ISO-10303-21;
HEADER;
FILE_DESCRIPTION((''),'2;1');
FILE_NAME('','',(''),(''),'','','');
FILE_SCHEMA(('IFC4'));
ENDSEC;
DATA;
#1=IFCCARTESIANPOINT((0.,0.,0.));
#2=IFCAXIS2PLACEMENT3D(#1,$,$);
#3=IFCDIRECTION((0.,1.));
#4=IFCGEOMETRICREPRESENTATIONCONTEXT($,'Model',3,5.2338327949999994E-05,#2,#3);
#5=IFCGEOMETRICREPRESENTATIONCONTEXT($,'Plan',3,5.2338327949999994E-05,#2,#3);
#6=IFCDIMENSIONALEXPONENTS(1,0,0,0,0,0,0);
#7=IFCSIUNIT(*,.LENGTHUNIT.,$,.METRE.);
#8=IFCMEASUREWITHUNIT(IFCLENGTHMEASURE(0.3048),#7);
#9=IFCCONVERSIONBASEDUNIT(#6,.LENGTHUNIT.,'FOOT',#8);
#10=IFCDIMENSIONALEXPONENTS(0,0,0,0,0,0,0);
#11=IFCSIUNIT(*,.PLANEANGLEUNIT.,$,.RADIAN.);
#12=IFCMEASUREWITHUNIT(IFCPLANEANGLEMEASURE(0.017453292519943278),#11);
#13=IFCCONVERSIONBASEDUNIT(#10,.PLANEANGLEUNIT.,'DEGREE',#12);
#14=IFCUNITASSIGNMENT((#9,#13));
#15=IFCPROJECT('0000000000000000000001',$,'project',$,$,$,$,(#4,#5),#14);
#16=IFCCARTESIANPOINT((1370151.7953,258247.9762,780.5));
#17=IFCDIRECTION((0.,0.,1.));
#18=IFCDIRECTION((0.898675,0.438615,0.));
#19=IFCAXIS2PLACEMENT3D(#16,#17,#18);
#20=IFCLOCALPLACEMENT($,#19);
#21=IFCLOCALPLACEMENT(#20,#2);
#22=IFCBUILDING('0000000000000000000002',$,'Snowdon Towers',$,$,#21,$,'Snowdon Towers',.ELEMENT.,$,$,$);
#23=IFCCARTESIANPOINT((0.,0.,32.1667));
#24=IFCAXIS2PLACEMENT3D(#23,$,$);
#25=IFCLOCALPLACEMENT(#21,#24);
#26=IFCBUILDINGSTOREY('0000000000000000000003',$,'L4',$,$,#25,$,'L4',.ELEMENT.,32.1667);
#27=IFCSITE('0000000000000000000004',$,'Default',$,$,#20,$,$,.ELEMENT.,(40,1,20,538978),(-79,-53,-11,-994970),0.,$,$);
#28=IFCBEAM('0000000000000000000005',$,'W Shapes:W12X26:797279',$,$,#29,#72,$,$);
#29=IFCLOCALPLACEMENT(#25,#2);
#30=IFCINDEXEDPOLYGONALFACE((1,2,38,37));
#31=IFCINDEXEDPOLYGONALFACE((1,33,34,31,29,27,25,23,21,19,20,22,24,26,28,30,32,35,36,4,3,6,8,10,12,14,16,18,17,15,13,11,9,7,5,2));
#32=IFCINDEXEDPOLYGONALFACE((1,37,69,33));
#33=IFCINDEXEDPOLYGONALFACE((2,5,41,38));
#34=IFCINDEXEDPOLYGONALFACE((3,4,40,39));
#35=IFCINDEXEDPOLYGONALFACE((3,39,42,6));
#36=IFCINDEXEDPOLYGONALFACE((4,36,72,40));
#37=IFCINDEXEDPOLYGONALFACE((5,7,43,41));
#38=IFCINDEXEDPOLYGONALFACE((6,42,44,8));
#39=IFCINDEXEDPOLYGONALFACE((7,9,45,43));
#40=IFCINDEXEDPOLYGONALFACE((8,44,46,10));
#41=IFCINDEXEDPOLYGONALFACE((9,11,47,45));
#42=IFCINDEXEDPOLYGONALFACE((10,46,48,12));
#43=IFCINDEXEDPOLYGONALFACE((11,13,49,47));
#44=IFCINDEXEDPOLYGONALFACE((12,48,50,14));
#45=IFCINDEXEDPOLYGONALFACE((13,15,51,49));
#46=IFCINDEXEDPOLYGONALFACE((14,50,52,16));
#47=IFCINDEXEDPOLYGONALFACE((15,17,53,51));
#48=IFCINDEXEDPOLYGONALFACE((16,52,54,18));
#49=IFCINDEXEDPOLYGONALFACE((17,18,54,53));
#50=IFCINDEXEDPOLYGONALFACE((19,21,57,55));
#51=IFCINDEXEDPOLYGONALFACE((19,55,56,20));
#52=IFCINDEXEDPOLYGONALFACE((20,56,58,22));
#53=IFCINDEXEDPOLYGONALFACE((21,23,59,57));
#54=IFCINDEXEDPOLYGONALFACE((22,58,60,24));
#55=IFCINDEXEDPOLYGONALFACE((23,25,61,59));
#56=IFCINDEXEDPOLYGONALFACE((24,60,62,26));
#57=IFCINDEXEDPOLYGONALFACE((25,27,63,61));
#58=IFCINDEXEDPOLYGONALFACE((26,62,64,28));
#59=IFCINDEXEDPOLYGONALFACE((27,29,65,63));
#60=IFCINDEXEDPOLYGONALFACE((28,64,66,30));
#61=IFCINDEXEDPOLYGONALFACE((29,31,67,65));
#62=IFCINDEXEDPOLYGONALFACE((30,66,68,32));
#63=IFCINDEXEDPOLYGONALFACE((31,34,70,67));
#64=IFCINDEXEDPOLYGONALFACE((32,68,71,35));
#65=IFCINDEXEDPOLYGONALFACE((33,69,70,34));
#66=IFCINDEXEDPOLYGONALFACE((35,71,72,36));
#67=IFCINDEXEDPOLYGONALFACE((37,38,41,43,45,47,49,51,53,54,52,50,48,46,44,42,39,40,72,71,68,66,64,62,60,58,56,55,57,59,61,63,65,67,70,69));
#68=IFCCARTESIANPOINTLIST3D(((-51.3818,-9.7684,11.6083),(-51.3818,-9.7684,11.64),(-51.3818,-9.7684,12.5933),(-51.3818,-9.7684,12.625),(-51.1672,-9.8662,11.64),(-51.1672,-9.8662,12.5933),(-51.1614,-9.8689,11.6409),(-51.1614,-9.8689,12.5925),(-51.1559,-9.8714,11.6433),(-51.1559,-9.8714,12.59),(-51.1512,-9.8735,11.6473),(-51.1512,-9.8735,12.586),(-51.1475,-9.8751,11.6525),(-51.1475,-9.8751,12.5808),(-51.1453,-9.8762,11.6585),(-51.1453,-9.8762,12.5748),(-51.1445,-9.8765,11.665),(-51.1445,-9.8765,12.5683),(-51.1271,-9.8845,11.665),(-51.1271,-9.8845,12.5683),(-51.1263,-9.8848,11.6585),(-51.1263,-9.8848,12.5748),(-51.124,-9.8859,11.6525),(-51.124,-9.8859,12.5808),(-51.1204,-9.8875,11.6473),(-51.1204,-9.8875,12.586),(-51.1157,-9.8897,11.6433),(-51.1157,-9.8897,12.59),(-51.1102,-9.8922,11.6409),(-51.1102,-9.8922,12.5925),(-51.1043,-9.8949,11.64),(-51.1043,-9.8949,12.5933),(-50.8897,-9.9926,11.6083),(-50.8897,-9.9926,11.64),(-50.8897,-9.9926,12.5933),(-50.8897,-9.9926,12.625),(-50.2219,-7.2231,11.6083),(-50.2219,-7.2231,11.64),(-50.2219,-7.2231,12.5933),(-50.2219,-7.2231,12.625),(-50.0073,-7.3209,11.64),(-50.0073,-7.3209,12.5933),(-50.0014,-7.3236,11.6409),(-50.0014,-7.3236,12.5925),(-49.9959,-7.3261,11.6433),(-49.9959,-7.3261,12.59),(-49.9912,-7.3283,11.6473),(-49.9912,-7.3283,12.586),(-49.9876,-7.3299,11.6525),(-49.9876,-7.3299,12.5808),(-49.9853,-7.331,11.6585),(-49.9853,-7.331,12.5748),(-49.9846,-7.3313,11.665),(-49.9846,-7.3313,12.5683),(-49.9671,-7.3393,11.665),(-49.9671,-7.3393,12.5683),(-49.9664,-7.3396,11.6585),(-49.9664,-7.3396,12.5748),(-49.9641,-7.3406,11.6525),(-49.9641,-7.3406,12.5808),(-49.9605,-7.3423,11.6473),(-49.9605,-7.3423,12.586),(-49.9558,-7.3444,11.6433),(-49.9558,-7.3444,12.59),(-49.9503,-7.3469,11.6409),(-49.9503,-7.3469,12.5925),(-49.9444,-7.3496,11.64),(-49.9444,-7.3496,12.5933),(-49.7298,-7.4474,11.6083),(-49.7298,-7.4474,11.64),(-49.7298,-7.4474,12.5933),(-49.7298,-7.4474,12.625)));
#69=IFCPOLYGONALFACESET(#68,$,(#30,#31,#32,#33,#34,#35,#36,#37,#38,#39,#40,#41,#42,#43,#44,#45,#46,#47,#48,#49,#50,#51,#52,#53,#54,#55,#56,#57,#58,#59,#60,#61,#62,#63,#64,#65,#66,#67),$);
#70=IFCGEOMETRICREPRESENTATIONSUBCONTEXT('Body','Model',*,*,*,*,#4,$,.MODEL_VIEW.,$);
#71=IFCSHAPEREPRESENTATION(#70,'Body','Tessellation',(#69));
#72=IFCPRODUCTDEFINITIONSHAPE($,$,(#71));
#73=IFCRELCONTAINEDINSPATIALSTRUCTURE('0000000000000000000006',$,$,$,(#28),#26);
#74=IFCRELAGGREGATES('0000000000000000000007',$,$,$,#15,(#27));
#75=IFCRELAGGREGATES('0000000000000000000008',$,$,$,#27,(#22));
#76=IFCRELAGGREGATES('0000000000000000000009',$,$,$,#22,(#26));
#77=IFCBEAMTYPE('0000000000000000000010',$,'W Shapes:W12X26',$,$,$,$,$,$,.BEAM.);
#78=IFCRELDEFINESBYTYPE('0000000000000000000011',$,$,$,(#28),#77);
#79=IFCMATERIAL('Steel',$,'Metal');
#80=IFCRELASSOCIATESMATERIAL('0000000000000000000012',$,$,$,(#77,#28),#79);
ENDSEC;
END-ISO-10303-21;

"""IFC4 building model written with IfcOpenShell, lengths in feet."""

from ifc_helpers import new_model, entity, si_unit, converted_unit, direction, frame, origin, place, context, subcontext, project, spatial, line, arc, indexed_curve, outline, extrude, source, transform, mapped, material, type_object, type_shapes, element, save


model = new_model("IFC4")

# Units and contexts
model_context = context("Model", 3, precision=5.2338327949999994e-05, world=origin(), true_north=direction((0.0, 1.0)))
plan_context = context("Plan", 3, precision=5.2338327949999994e-05, world=origin(), true_north=direction((0.0, 1.0)))
body_context = subcontext(model_context, "Body", "Model", "MODEL_VIEW")
ifc_project = project(units=[converted_unit("LENGTHUNIT", "FOOT", entity("IfcLengthMeasure", 0.3048), si_unit("LENGTHUNIT", "METRE"), dimensions=[1, 0, 0, 0, 0, 0, 0]), converted_unit("PLANEANGLEUNIT", "DEGREE", entity("IfcPlaneAngleMeasure", 0.017453292519943278), si_unit("PLANEANGLEUNIT", "RADIAN"), dimensions=[0, 0, 0, 0, 0, 0, 0])], contexts=[model_context, plan_context])

# Site, building, storey
site_placement = place(None, frame((1370151.7953, 258247.9762, 780.5), z_axis=(0.0, 0.0, 1.0), x_axis=(0.898675, 0.438615, 0.0)))
site = spatial("IfcSite", under=ifc_project, at=site_placement, Name="Default", CompositionType="ELEMENT", RefLatitude=(40, 1, 20, 538978), RefLongitude=(-79, -53, -11, -994970), RefElevation=0.0)
building_placement = place(site_placement, origin())
building = spatial("IfcBuilding", under=site, at=building_placement, Name="Snowdon Towers", LongName="Snowdon Towers", CompositionType="ELEMENT")
storey_placement = place(building_placement, frame((0.0, 0.0, 32.1667)))
storey = spatial("IfcBuildingStorey", under=building, at=storey_placement, Name="L4", LongName="L4", CompositionType="ELEMENT", Elevation=32.1667)

# Beam
ifc_material = material(Name="Steel", Category="Metal")
beam_type_1 = type_object("IfcBeamType", Name="W Shapes:W12X26", PredefinedType="BEAM", material=ifc_material)
shared_shape_1 = source(origin(), body_context, "Body", "SweptSolid", [
    extrude(outline(indexed_curve([(0.4767, -0.2704), (0.5083, -0.2704), (0.5083, 0.2704), (0.4767, 0.2704), (0.4767, 0.0346), (0.4693, 0.0169), (0.4517, 0.0096), (-0.4517, 0.0096), (-0.4693, 0.0169), (-0.4767, 0.0346), (-0.4767, 0.2704), (-0.5083, 0.2704), (-0.5083, -0.2704), (-0.4767, -0.2704), (-0.4767, -0.0346), (-0.4693, -0.0169), (-0.4517, -0.0096), (0.4517, -0.0096), (0.4693, -0.0169), (0.4767, -0.0346)], segments=[line(1, 2, 3, 4, 5), arc(5, 6, 7), line(7, 8), arc(8, 9, 10), line(10, 11, 12, 13, 14, 15), arc(15, 16, 17), line(17, 18), arc(18, 19, 20), line(20, 1)], self_intersect=False)), frame((-51.1358, -9.8805, 44.2833), z_axis=(0.414693, 0.909961, 0.0), x_axis=(0.0, 0.0, 1.0)), (0.0, 0.0, 1.0), 2.7971),
])
type_shapes(beam_type_1, [shared_shape_1])
beam_1_placement = place(storey_placement, frame((0.0, 0.0, -32.1667)))
element("IfcBeam", 1, at=beam_1_placement, inside=storey, type_object=beam_type_1, material=ifc_material, Name="W Shapes:W12X26:797279", context=body_context, shape_type="MappedRepresentation", body=[
    mapped(shared_shape_1, transform((0.0, 0.0, 0.0), scale=1.0)),
])

save(model, "model.ifc")
